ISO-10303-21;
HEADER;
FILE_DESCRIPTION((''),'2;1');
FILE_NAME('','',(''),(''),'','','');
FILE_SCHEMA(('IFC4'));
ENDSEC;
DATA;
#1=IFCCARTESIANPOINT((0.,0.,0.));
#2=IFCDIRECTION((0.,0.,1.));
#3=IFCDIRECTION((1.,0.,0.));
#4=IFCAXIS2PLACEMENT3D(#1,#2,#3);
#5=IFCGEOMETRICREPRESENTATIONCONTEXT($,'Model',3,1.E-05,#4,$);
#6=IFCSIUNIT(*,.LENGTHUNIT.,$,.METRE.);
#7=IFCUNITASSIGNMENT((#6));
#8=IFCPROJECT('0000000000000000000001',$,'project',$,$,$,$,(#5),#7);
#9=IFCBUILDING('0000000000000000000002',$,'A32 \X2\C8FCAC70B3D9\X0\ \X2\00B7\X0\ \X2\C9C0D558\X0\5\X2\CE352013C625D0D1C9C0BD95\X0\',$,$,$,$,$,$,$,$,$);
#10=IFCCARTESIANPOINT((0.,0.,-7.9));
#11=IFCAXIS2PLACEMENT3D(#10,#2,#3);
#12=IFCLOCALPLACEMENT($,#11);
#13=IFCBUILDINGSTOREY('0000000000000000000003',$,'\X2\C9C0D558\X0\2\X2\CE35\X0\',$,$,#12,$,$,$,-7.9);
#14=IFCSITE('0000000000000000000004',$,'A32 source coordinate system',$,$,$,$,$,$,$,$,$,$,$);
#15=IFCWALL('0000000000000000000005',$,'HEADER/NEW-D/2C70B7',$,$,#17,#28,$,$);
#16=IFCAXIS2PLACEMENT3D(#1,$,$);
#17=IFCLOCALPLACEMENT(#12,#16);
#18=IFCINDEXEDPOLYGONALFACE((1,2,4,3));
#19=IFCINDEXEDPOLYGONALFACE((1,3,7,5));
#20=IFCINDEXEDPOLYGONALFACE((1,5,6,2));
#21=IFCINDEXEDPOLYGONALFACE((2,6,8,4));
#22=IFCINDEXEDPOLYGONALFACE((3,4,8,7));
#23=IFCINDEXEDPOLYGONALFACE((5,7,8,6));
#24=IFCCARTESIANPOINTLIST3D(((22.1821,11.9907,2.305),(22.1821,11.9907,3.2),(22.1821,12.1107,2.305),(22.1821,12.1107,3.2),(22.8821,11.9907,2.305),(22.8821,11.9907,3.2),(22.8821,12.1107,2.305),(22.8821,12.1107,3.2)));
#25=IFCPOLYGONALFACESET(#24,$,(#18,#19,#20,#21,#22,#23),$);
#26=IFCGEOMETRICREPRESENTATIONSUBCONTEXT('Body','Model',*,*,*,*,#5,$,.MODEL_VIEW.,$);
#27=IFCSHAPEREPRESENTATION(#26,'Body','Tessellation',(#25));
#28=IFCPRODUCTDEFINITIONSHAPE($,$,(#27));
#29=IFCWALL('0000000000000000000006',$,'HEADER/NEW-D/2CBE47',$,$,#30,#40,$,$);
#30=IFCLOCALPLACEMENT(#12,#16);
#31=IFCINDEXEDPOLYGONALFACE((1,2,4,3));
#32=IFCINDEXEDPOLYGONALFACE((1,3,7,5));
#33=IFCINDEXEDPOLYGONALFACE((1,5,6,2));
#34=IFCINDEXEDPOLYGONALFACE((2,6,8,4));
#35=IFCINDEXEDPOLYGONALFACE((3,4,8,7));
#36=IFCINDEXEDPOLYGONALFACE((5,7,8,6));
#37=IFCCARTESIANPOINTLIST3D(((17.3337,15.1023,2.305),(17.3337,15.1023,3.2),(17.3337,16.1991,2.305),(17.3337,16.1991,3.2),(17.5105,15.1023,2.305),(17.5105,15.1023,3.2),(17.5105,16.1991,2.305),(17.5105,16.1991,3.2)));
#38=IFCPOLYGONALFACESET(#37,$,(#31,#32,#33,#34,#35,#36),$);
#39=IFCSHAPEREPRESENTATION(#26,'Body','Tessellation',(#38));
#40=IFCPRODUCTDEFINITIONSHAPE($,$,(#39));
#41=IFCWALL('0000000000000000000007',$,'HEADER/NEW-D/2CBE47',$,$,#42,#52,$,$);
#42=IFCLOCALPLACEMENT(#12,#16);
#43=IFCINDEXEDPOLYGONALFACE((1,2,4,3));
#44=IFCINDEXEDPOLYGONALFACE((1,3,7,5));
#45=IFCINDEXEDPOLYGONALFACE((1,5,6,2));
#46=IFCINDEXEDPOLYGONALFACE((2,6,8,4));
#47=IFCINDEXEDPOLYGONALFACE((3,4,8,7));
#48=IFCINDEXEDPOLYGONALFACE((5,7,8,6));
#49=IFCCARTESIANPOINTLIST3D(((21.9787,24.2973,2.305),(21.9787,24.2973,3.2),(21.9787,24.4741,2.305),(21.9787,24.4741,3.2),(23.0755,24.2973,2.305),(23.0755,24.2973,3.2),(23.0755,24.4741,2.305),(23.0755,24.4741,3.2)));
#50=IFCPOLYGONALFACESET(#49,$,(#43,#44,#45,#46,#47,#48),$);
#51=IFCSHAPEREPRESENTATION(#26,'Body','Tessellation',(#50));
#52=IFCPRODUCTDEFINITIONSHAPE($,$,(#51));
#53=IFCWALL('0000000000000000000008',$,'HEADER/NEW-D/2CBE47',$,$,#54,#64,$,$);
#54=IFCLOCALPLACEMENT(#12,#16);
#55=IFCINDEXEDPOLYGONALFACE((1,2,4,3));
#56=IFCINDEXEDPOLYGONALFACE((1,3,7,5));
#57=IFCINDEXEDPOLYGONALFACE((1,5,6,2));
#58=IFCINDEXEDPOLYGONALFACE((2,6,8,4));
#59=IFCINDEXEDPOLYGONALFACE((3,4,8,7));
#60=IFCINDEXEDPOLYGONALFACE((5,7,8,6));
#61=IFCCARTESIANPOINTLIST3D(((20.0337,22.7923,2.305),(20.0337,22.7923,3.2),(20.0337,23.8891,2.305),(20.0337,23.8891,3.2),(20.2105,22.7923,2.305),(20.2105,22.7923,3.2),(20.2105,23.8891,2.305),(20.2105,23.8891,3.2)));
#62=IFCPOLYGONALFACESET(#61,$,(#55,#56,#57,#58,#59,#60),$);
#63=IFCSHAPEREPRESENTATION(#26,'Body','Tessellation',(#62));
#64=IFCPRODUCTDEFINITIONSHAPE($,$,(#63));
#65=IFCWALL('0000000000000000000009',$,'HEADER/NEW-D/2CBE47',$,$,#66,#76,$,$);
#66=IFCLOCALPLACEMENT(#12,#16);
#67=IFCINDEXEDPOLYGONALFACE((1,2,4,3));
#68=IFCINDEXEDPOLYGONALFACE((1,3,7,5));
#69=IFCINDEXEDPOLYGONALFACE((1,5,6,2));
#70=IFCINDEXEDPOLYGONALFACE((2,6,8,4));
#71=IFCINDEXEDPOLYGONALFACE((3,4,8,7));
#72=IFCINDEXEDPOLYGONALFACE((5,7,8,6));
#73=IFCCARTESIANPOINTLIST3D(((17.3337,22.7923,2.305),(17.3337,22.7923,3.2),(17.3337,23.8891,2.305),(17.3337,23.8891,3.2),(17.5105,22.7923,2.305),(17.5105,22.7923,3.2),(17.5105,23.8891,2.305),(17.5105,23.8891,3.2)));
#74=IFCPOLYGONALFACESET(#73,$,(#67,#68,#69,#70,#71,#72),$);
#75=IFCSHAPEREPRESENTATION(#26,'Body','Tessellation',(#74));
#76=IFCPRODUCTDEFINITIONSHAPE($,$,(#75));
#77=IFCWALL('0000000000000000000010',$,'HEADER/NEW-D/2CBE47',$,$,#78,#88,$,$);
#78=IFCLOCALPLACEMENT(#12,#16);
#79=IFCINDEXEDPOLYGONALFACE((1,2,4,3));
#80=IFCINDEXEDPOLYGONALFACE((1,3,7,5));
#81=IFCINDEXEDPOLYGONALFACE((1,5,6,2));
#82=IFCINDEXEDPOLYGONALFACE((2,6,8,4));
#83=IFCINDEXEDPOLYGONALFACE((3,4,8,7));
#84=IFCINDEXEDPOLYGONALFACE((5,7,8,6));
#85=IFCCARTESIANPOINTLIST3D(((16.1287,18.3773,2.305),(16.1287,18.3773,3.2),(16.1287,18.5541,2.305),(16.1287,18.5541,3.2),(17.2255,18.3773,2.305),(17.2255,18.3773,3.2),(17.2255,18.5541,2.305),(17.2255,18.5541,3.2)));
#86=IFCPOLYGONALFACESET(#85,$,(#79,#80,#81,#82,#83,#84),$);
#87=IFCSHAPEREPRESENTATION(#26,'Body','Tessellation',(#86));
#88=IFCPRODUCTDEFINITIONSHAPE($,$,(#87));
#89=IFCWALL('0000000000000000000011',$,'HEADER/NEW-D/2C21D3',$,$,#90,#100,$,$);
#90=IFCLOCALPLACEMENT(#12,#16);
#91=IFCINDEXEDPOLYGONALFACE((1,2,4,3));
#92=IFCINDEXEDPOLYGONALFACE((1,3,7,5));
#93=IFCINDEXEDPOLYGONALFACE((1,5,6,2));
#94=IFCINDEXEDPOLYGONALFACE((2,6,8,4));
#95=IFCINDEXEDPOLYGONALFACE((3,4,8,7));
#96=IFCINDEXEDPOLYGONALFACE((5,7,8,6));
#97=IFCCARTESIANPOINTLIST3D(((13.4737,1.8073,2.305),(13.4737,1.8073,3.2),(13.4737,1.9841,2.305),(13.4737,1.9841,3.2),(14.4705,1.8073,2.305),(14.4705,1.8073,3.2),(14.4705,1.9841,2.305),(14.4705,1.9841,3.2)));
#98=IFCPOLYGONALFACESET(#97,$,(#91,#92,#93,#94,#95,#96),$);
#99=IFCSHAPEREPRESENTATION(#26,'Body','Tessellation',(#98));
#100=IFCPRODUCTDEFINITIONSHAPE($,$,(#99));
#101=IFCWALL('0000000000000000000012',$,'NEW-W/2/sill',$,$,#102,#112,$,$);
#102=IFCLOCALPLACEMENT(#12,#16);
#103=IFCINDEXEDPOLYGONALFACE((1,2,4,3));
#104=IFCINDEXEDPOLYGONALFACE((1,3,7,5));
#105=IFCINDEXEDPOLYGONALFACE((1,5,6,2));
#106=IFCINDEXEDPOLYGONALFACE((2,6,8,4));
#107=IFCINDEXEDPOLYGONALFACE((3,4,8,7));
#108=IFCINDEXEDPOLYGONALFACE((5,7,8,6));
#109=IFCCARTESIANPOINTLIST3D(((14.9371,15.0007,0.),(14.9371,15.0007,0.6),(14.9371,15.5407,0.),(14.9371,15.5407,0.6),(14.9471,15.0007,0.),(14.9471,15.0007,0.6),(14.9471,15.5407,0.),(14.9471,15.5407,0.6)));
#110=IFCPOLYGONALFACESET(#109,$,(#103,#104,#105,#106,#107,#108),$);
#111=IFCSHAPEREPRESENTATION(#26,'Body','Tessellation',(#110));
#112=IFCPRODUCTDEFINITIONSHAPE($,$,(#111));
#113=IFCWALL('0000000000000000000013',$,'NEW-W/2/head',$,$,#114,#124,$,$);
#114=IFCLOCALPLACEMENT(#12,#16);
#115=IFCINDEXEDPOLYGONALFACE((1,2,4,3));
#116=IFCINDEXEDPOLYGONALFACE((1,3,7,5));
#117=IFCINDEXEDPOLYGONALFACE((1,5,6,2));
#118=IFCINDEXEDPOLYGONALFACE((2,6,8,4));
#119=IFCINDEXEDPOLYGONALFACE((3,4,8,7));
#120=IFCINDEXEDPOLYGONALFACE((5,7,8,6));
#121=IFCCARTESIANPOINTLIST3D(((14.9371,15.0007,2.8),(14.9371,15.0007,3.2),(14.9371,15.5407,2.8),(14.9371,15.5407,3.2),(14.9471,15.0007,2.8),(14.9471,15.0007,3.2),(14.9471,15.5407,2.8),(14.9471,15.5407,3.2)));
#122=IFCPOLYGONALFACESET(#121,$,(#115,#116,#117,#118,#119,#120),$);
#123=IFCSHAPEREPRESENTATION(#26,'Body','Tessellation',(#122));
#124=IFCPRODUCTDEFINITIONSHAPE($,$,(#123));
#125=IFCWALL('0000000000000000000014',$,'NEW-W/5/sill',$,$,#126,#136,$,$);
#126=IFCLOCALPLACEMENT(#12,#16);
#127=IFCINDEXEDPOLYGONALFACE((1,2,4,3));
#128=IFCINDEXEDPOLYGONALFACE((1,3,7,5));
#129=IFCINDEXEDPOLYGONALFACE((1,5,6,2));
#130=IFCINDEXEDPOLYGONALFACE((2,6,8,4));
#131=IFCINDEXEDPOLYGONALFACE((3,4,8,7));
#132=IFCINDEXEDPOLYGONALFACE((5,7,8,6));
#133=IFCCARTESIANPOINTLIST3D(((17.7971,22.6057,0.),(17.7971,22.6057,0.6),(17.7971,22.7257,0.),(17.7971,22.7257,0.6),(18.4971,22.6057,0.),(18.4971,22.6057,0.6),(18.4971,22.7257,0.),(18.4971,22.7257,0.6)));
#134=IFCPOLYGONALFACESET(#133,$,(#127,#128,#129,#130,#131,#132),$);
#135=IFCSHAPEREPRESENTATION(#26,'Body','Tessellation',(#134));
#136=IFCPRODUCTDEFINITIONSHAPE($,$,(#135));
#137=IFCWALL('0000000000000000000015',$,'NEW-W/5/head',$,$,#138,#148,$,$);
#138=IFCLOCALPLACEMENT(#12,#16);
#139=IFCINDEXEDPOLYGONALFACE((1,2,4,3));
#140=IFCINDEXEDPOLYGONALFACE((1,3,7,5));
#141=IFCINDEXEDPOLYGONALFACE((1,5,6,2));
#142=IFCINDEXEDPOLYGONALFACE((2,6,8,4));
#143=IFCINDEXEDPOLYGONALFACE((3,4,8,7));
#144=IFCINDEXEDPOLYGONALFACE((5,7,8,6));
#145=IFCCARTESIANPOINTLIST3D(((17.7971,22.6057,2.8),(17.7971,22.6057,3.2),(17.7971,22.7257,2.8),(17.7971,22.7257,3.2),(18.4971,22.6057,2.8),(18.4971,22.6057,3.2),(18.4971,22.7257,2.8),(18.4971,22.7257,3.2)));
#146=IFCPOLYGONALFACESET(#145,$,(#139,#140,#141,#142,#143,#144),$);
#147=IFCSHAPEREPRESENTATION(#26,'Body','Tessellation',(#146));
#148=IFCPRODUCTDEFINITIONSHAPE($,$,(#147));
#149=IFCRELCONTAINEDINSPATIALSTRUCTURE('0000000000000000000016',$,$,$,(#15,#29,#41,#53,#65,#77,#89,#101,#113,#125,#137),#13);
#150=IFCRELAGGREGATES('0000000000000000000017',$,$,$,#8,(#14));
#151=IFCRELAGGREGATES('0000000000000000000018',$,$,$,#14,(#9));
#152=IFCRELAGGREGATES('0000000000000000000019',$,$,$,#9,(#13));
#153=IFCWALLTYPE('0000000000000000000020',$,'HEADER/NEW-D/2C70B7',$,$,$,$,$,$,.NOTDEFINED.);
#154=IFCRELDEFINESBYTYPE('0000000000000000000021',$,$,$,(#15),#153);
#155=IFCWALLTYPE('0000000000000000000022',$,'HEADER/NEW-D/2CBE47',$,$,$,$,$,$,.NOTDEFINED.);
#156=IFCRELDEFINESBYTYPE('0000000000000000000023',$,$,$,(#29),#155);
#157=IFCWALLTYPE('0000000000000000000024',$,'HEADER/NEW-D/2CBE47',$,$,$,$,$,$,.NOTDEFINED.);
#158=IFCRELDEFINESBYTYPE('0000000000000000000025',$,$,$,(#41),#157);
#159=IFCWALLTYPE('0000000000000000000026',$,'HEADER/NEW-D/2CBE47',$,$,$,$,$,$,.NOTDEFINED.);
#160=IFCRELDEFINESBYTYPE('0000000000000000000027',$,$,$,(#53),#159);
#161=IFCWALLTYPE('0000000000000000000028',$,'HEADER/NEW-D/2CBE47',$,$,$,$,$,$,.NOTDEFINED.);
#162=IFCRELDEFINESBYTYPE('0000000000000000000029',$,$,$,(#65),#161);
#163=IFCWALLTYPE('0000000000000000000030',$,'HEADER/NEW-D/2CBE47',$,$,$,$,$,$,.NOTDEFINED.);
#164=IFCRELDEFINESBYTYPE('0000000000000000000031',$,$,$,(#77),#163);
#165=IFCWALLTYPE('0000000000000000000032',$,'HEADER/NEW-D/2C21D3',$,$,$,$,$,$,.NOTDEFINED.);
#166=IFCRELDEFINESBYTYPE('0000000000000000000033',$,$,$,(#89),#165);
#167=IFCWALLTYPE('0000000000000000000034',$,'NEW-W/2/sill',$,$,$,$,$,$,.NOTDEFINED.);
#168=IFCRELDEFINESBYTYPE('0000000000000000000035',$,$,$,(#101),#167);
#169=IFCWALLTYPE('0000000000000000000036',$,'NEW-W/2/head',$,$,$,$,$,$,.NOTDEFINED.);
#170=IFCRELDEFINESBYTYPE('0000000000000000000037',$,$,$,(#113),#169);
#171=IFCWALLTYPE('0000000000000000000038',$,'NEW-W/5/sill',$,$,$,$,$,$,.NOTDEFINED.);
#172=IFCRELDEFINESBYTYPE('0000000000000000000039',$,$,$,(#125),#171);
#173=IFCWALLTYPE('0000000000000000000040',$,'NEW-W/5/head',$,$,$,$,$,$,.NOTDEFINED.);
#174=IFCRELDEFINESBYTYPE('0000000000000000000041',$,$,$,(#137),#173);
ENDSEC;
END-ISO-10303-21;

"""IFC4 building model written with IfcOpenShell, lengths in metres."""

from ifc_helpers import new_model, si_unit, frame, origin, origin_with_axes, place, context, subcontext, project, spatial, polyline, outline, extrude, source, transform, mapped, type_object, type_shapes, element, save


model = new_model("IFC4")

# Units and contexts
model_context = context("Model", 3, precision=1e-05, world=origin_with_axes())
body_context = subcontext(model_context, "Body", "Model", "MODEL_VIEW")
ifc_project = project(units=[si_unit("LENGTHUNIT", "METRE")], contexts=[model_context])

# Site, building, storey
site = spatial("IfcSite", under=ifc_project, Name="A32 source coordinate system")
building = spatial("IfcBuilding", under=site, Name="A32 주거동 · 지하5층–옥탑지붕")
storey_placement = place(None, frame((0.0, 0.0, -7.9), z_axis=(0.0, 0.0, 1.0), x_axis=(1.0, 0.0, 0.0)))
storey = spatial("IfcBuildingStorey", under=building, at=storey_placement, Name="지하2층", Elevation=-7.9)

# Walls
wall_type_1 = type_object("IfcWallType", Name="HEADER/NEW-D/2C70B7", PredefinedType="NOTDEFINED")
shared_shape_1 = source(origin(), body_context, "Body", "SweptSolid", [
    extrude(outline(polyline([(22.1821, 11.9907), (22.1821, 12.1107), (22.8821, 12.1107), (22.8821, 11.9907), (22.1821, 11.9907)])), frame((0.0, 0.0, 2.305)), (0.0, 0.0, 1.0), 0.895),
])
type_shapes(wall_type_1, [shared_shape_1])
wall_1_placement = place(storey_placement, origin_with_axes())
element("IfcWall", 1, at=wall_1_placement, inside=storey, type_object=wall_type_1, Name="HEADER/NEW-D/2C70B7", context=body_context, shape_type="MappedRepresentation", body=[
    mapped(shared_shape_1, transform((0.0, 0.0, 0.0), scale=1.0)),
])
wall_type_2 = type_object("IfcWallType", Name="HEADER/NEW-D/2CBE47", PredefinedType="NOTDEFINED")
shared_shape_2 = source(origin(), body_context, "Body", "SweptSolid", [
    extrude(outline(polyline([(17.3337, 15.1023), (17.3337, 16.1991), (17.5105, 16.1991), (17.5105, 15.1023), (17.3337, 15.1023)])), frame((0.0, 0.0, 2.305)), (0.0, 0.0, 1.0), 0.895),
])
type_shapes(wall_type_2, [shared_shape_2])
wall_2_placement = place(storey_placement, origin_with_axes())
element("IfcWall", 2, at=wall_2_placement, inside=storey, type_object=wall_type_2, Name="HEADER/NEW-D/2CBE47", context=body_context, shape_type="MappedRepresentation", body=[
    mapped(shared_shape_2, transform((0.0, 0.0, 0.0), scale=1.0)),
])
wall_type_3 = type_object("IfcWallType", Name="HEADER/NEW-D/2CBE47", PredefinedType="NOTDEFINED")
shared_shape_3 = source(origin(), body_context, "Body", "SweptSolid", [
    extrude(outline(polyline([(21.9787, 24.2973), (21.9787, 24.4741), (23.0755, 24.4741), (23.0755, 24.2973), (21.9787, 24.2973)])), frame((0.0, 0.0, 2.305)), (0.0, 0.0, 1.0), 0.895),
])
type_shapes(wall_type_3, [shared_shape_3])
wall_3_placement = place(storey_placement, origin_with_axes())
element("IfcWall", 3, at=wall_3_placement, inside=storey, type_object=wall_type_3, Name="HEADER/NEW-D/2CBE47", context=body_context, shape_type="MappedRepresentation", body=[
    mapped(shared_shape_3, transform((0.0, 0.0, 0.0), scale=1.0)),
])
wall_type_4 = type_object("IfcWallType", Name="HEADER/NEW-D/2CBE47", PredefinedType="NOTDEFINED")
shared_shape_4 = source(origin(), body_context, "Body", "SweptSolid", [
    extrude(outline(polyline([(20.0337, 22.7923), (20.0337, 23.8891), (20.2105, 23.8891), (20.2105, 22.7923), (20.0337, 22.7923)])), frame((0.0, 0.0, 2.305)), (0.0, 0.0, 1.0), 0.895),
])
type_shapes(wall_type_4, [shared_shape_4])
wall_4_placement = place(storey_placement, origin_with_axes())
element("IfcWall", 4, at=wall_4_placement, inside=storey, type_object=wall_type_4, Name="HEADER/NEW-D/2CBE47", context=body_context, shape_type="MappedRepresentation", body=[
    mapped(shared_shape_4, transform((0.0, 0.0, 0.0), scale=1.0)),
])
wall_type_5 = type_object("IfcWallType", Name="HEADER/NEW-D/2CBE47", PredefinedType="NOTDEFINED")
shared_shape_5 = source(origin(), body_context, "Body", "SweptSolid", [
    extrude(outline(polyline([(17.3337, 22.7923), (17.3337, 23.8891), (17.5105, 23.8891), (17.5105, 22.7923), (17.3337, 22.7923)])), frame((0.0, 0.0, 2.305)), (0.0, 0.0, 1.0), 0.895),
])
type_shapes(wall_type_5, [shared_shape_5])
wall_5_placement = place(storey_placement, origin_with_axes())
element("IfcWall", 5, at=wall_5_placement, inside=storey, type_object=wall_type_5, Name="HEADER/NEW-D/2CBE47", context=body_context, shape_type="MappedRepresentation", body=[
    mapped(shared_shape_5, transform((0.0, 0.0, 0.0), scale=1.0)),
])
wall_type_6 = type_object("IfcWallType", Name="HEADER/NEW-D/2CBE47", PredefinedType="NOTDEFINED")
shared_shape_6 = source(origin(), body_context, "Body", "SweptSolid", [
    extrude(outline(polyline([(16.1287, 18.3773), (16.1287, 18.5541), (17.2255, 18.5541), (17.2255, 18.3773), (16.1287, 18.3773)])), frame((0.0, 0.0, 2.305)), (0.0, 0.0, 1.0), 0.895),
])
type_shapes(wall_type_6, [shared_shape_6])
wall_6_placement = place(storey_placement, origin_with_axes())
element("IfcWall", 6, at=wall_6_placement, inside=storey, type_object=wall_type_6, Name="HEADER/NEW-D/2CBE47", context=body_context, shape_type="MappedRepresentation", body=[
    mapped(shared_shape_6, transform((0.0, 0.0, 0.0), scale=1.0)),
])
wall_type_7 = type_object("IfcWallType", Name="HEADER/NEW-D/2C21D3", PredefinedType="NOTDEFINED")
shared_shape_7 = source(origin(), body_context, "Body", "SweptSolid", [
    extrude(outline(polyline([(13.4737, 1.8073), (13.4737, 1.9841), (14.4705, 1.9841), (14.4705, 1.8073), (13.4737, 1.8073)])), frame((0.0, 0.0, 2.305)), (0.0, 0.0, 1.0), 0.895),
])
type_shapes(wall_type_7, [shared_shape_7])
wall_7_placement = place(storey_placement, origin_with_axes())
element("IfcWall", 7, at=wall_7_placement, inside=storey, type_object=wall_type_7, Name="HEADER/NEW-D/2C21D3", context=body_context, shape_type="MappedRepresentation", body=[
    mapped(shared_shape_7, transform((0.0, 0.0, 0.0), scale=1.0)),
])
wall_type_8 = type_object("IfcWallType", Name="NEW-W/2/sill", PredefinedType="NOTDEFINED")
shared_shape_8 = source(origin(), body_context, "Body", "SweptSolid", [
    extrude(outline(polyline([(14.9471, 15.5407), (14.9471, 15.0007), (14.9371, 15.0007), (14.9371, 15.5407), (14.9471, 15.5407)])), origin(), (0.0, 0.0, 1.0), 0.6),
])
type_shapes(wall_type_8, [shared_shape_8])
wall_8_placement = place(storey_placement, origin_with_axes())
element("IfcWall", 8, at=wall_8_placement, inside=storey, type_object=wall_type_8, Name="NEW-W/2/sill", context=body_context, shape_type="MappedRepresentation", body=[
    mapped(shared_shape_8, transform((0.0, 0.0, 0.0), scale=1.0)),
])
wall_type_9 = type_object("IfcWallType", Name="NEW-W/2/head", PredefinedType="NOTDEFINED")
shared_shape_9 = source(origin(), body_context, "Body", "SweptSolid", [
    extrude(outline(polyline([(14.9471, 15.5407), (14.9471, 15.0007), (14.9371, 15.0007), (14.9371, 15.5407), (14.9471, 15.5407)])), frame((0.0, 0.0, 2.8)), (0.0, 0.0, 1.0), 0.4),
])
type_shapes(wall_type_9, [shared_shape_9])
wall_9_placement = place(storey_placement, origin_with_axes())
element("IfcWall", 9, at=wall_9_placement, inside=storey, type_object=wall_type_9, Name="NEW-W/2/head", context=body_context, shape_type="MappedRepresentation", body=[
    mapped(shared_shape_9, transform((0.0, 0.0, 0.0), scale=1.0)),
])
wall_type_10 = type_object("IfcWallType", Name="NEW-W/5/sill", PredefinedType="NOTDEFINED")
shared_shape_10 = source(origin(), body_context, "Body", "SweptSolid", [
    extrude(outline(polyline([(17.7971, 22.6057), (17.7971, 22.7257), (18.4971, 22.7257), (18.4971, 22.6057), (17.7971, 22.6057)])), origin(), (0.0, 0.0, 1.0), 0.6),
])
type_shapes(wall_type_10, [shared_shape_10])
wall_10_placement = place(storey_placement, origin_with_axes())
element("IfcWall", 10, at=wall_10_placement, inside=storey, type_object=wall_type_10, Name="NEW-W/5/sill", context=body_context, shape_type="MappedRepresentation", body=[
    mapped(shared_shape_10, transform((0.0, 0.0, 0.0), scale=1.0)),
])
wall_type_11 = type_object("IfcWallType", Name="NEW-W/5/head", PredefinedType="NOTDEFINED")
shared_shape_11 = source(origin(), body_context, "Body", "SweptSolid", [
    extrude(outline(polyline([(17.7971, 22.6057), (17.7971, 22.7257), (18.4971, 22.7257), (18.4971, 22.6057), (17.7971, 22.6057)])), frame((0.0, 0.0, 2.8)), (0.0, 0.0, 1.0), 0.4),
])
type_shapes(wall_type_11, [shared_shape_11])
wall_11_placement = place(storey_placement, origin_with_axes())
element("IfcWall", 11, at=wall_11_placement, inside=storey, type_object=wall_type_11, Name="NEW-W/5/head", context=body_context, shape_type="MappedRepresentation", body=[
    mapped(shared_shape_11, transform((0.0, 0.0, 0.0), scale=1.0)),
])

save(model, "model.ifc")
